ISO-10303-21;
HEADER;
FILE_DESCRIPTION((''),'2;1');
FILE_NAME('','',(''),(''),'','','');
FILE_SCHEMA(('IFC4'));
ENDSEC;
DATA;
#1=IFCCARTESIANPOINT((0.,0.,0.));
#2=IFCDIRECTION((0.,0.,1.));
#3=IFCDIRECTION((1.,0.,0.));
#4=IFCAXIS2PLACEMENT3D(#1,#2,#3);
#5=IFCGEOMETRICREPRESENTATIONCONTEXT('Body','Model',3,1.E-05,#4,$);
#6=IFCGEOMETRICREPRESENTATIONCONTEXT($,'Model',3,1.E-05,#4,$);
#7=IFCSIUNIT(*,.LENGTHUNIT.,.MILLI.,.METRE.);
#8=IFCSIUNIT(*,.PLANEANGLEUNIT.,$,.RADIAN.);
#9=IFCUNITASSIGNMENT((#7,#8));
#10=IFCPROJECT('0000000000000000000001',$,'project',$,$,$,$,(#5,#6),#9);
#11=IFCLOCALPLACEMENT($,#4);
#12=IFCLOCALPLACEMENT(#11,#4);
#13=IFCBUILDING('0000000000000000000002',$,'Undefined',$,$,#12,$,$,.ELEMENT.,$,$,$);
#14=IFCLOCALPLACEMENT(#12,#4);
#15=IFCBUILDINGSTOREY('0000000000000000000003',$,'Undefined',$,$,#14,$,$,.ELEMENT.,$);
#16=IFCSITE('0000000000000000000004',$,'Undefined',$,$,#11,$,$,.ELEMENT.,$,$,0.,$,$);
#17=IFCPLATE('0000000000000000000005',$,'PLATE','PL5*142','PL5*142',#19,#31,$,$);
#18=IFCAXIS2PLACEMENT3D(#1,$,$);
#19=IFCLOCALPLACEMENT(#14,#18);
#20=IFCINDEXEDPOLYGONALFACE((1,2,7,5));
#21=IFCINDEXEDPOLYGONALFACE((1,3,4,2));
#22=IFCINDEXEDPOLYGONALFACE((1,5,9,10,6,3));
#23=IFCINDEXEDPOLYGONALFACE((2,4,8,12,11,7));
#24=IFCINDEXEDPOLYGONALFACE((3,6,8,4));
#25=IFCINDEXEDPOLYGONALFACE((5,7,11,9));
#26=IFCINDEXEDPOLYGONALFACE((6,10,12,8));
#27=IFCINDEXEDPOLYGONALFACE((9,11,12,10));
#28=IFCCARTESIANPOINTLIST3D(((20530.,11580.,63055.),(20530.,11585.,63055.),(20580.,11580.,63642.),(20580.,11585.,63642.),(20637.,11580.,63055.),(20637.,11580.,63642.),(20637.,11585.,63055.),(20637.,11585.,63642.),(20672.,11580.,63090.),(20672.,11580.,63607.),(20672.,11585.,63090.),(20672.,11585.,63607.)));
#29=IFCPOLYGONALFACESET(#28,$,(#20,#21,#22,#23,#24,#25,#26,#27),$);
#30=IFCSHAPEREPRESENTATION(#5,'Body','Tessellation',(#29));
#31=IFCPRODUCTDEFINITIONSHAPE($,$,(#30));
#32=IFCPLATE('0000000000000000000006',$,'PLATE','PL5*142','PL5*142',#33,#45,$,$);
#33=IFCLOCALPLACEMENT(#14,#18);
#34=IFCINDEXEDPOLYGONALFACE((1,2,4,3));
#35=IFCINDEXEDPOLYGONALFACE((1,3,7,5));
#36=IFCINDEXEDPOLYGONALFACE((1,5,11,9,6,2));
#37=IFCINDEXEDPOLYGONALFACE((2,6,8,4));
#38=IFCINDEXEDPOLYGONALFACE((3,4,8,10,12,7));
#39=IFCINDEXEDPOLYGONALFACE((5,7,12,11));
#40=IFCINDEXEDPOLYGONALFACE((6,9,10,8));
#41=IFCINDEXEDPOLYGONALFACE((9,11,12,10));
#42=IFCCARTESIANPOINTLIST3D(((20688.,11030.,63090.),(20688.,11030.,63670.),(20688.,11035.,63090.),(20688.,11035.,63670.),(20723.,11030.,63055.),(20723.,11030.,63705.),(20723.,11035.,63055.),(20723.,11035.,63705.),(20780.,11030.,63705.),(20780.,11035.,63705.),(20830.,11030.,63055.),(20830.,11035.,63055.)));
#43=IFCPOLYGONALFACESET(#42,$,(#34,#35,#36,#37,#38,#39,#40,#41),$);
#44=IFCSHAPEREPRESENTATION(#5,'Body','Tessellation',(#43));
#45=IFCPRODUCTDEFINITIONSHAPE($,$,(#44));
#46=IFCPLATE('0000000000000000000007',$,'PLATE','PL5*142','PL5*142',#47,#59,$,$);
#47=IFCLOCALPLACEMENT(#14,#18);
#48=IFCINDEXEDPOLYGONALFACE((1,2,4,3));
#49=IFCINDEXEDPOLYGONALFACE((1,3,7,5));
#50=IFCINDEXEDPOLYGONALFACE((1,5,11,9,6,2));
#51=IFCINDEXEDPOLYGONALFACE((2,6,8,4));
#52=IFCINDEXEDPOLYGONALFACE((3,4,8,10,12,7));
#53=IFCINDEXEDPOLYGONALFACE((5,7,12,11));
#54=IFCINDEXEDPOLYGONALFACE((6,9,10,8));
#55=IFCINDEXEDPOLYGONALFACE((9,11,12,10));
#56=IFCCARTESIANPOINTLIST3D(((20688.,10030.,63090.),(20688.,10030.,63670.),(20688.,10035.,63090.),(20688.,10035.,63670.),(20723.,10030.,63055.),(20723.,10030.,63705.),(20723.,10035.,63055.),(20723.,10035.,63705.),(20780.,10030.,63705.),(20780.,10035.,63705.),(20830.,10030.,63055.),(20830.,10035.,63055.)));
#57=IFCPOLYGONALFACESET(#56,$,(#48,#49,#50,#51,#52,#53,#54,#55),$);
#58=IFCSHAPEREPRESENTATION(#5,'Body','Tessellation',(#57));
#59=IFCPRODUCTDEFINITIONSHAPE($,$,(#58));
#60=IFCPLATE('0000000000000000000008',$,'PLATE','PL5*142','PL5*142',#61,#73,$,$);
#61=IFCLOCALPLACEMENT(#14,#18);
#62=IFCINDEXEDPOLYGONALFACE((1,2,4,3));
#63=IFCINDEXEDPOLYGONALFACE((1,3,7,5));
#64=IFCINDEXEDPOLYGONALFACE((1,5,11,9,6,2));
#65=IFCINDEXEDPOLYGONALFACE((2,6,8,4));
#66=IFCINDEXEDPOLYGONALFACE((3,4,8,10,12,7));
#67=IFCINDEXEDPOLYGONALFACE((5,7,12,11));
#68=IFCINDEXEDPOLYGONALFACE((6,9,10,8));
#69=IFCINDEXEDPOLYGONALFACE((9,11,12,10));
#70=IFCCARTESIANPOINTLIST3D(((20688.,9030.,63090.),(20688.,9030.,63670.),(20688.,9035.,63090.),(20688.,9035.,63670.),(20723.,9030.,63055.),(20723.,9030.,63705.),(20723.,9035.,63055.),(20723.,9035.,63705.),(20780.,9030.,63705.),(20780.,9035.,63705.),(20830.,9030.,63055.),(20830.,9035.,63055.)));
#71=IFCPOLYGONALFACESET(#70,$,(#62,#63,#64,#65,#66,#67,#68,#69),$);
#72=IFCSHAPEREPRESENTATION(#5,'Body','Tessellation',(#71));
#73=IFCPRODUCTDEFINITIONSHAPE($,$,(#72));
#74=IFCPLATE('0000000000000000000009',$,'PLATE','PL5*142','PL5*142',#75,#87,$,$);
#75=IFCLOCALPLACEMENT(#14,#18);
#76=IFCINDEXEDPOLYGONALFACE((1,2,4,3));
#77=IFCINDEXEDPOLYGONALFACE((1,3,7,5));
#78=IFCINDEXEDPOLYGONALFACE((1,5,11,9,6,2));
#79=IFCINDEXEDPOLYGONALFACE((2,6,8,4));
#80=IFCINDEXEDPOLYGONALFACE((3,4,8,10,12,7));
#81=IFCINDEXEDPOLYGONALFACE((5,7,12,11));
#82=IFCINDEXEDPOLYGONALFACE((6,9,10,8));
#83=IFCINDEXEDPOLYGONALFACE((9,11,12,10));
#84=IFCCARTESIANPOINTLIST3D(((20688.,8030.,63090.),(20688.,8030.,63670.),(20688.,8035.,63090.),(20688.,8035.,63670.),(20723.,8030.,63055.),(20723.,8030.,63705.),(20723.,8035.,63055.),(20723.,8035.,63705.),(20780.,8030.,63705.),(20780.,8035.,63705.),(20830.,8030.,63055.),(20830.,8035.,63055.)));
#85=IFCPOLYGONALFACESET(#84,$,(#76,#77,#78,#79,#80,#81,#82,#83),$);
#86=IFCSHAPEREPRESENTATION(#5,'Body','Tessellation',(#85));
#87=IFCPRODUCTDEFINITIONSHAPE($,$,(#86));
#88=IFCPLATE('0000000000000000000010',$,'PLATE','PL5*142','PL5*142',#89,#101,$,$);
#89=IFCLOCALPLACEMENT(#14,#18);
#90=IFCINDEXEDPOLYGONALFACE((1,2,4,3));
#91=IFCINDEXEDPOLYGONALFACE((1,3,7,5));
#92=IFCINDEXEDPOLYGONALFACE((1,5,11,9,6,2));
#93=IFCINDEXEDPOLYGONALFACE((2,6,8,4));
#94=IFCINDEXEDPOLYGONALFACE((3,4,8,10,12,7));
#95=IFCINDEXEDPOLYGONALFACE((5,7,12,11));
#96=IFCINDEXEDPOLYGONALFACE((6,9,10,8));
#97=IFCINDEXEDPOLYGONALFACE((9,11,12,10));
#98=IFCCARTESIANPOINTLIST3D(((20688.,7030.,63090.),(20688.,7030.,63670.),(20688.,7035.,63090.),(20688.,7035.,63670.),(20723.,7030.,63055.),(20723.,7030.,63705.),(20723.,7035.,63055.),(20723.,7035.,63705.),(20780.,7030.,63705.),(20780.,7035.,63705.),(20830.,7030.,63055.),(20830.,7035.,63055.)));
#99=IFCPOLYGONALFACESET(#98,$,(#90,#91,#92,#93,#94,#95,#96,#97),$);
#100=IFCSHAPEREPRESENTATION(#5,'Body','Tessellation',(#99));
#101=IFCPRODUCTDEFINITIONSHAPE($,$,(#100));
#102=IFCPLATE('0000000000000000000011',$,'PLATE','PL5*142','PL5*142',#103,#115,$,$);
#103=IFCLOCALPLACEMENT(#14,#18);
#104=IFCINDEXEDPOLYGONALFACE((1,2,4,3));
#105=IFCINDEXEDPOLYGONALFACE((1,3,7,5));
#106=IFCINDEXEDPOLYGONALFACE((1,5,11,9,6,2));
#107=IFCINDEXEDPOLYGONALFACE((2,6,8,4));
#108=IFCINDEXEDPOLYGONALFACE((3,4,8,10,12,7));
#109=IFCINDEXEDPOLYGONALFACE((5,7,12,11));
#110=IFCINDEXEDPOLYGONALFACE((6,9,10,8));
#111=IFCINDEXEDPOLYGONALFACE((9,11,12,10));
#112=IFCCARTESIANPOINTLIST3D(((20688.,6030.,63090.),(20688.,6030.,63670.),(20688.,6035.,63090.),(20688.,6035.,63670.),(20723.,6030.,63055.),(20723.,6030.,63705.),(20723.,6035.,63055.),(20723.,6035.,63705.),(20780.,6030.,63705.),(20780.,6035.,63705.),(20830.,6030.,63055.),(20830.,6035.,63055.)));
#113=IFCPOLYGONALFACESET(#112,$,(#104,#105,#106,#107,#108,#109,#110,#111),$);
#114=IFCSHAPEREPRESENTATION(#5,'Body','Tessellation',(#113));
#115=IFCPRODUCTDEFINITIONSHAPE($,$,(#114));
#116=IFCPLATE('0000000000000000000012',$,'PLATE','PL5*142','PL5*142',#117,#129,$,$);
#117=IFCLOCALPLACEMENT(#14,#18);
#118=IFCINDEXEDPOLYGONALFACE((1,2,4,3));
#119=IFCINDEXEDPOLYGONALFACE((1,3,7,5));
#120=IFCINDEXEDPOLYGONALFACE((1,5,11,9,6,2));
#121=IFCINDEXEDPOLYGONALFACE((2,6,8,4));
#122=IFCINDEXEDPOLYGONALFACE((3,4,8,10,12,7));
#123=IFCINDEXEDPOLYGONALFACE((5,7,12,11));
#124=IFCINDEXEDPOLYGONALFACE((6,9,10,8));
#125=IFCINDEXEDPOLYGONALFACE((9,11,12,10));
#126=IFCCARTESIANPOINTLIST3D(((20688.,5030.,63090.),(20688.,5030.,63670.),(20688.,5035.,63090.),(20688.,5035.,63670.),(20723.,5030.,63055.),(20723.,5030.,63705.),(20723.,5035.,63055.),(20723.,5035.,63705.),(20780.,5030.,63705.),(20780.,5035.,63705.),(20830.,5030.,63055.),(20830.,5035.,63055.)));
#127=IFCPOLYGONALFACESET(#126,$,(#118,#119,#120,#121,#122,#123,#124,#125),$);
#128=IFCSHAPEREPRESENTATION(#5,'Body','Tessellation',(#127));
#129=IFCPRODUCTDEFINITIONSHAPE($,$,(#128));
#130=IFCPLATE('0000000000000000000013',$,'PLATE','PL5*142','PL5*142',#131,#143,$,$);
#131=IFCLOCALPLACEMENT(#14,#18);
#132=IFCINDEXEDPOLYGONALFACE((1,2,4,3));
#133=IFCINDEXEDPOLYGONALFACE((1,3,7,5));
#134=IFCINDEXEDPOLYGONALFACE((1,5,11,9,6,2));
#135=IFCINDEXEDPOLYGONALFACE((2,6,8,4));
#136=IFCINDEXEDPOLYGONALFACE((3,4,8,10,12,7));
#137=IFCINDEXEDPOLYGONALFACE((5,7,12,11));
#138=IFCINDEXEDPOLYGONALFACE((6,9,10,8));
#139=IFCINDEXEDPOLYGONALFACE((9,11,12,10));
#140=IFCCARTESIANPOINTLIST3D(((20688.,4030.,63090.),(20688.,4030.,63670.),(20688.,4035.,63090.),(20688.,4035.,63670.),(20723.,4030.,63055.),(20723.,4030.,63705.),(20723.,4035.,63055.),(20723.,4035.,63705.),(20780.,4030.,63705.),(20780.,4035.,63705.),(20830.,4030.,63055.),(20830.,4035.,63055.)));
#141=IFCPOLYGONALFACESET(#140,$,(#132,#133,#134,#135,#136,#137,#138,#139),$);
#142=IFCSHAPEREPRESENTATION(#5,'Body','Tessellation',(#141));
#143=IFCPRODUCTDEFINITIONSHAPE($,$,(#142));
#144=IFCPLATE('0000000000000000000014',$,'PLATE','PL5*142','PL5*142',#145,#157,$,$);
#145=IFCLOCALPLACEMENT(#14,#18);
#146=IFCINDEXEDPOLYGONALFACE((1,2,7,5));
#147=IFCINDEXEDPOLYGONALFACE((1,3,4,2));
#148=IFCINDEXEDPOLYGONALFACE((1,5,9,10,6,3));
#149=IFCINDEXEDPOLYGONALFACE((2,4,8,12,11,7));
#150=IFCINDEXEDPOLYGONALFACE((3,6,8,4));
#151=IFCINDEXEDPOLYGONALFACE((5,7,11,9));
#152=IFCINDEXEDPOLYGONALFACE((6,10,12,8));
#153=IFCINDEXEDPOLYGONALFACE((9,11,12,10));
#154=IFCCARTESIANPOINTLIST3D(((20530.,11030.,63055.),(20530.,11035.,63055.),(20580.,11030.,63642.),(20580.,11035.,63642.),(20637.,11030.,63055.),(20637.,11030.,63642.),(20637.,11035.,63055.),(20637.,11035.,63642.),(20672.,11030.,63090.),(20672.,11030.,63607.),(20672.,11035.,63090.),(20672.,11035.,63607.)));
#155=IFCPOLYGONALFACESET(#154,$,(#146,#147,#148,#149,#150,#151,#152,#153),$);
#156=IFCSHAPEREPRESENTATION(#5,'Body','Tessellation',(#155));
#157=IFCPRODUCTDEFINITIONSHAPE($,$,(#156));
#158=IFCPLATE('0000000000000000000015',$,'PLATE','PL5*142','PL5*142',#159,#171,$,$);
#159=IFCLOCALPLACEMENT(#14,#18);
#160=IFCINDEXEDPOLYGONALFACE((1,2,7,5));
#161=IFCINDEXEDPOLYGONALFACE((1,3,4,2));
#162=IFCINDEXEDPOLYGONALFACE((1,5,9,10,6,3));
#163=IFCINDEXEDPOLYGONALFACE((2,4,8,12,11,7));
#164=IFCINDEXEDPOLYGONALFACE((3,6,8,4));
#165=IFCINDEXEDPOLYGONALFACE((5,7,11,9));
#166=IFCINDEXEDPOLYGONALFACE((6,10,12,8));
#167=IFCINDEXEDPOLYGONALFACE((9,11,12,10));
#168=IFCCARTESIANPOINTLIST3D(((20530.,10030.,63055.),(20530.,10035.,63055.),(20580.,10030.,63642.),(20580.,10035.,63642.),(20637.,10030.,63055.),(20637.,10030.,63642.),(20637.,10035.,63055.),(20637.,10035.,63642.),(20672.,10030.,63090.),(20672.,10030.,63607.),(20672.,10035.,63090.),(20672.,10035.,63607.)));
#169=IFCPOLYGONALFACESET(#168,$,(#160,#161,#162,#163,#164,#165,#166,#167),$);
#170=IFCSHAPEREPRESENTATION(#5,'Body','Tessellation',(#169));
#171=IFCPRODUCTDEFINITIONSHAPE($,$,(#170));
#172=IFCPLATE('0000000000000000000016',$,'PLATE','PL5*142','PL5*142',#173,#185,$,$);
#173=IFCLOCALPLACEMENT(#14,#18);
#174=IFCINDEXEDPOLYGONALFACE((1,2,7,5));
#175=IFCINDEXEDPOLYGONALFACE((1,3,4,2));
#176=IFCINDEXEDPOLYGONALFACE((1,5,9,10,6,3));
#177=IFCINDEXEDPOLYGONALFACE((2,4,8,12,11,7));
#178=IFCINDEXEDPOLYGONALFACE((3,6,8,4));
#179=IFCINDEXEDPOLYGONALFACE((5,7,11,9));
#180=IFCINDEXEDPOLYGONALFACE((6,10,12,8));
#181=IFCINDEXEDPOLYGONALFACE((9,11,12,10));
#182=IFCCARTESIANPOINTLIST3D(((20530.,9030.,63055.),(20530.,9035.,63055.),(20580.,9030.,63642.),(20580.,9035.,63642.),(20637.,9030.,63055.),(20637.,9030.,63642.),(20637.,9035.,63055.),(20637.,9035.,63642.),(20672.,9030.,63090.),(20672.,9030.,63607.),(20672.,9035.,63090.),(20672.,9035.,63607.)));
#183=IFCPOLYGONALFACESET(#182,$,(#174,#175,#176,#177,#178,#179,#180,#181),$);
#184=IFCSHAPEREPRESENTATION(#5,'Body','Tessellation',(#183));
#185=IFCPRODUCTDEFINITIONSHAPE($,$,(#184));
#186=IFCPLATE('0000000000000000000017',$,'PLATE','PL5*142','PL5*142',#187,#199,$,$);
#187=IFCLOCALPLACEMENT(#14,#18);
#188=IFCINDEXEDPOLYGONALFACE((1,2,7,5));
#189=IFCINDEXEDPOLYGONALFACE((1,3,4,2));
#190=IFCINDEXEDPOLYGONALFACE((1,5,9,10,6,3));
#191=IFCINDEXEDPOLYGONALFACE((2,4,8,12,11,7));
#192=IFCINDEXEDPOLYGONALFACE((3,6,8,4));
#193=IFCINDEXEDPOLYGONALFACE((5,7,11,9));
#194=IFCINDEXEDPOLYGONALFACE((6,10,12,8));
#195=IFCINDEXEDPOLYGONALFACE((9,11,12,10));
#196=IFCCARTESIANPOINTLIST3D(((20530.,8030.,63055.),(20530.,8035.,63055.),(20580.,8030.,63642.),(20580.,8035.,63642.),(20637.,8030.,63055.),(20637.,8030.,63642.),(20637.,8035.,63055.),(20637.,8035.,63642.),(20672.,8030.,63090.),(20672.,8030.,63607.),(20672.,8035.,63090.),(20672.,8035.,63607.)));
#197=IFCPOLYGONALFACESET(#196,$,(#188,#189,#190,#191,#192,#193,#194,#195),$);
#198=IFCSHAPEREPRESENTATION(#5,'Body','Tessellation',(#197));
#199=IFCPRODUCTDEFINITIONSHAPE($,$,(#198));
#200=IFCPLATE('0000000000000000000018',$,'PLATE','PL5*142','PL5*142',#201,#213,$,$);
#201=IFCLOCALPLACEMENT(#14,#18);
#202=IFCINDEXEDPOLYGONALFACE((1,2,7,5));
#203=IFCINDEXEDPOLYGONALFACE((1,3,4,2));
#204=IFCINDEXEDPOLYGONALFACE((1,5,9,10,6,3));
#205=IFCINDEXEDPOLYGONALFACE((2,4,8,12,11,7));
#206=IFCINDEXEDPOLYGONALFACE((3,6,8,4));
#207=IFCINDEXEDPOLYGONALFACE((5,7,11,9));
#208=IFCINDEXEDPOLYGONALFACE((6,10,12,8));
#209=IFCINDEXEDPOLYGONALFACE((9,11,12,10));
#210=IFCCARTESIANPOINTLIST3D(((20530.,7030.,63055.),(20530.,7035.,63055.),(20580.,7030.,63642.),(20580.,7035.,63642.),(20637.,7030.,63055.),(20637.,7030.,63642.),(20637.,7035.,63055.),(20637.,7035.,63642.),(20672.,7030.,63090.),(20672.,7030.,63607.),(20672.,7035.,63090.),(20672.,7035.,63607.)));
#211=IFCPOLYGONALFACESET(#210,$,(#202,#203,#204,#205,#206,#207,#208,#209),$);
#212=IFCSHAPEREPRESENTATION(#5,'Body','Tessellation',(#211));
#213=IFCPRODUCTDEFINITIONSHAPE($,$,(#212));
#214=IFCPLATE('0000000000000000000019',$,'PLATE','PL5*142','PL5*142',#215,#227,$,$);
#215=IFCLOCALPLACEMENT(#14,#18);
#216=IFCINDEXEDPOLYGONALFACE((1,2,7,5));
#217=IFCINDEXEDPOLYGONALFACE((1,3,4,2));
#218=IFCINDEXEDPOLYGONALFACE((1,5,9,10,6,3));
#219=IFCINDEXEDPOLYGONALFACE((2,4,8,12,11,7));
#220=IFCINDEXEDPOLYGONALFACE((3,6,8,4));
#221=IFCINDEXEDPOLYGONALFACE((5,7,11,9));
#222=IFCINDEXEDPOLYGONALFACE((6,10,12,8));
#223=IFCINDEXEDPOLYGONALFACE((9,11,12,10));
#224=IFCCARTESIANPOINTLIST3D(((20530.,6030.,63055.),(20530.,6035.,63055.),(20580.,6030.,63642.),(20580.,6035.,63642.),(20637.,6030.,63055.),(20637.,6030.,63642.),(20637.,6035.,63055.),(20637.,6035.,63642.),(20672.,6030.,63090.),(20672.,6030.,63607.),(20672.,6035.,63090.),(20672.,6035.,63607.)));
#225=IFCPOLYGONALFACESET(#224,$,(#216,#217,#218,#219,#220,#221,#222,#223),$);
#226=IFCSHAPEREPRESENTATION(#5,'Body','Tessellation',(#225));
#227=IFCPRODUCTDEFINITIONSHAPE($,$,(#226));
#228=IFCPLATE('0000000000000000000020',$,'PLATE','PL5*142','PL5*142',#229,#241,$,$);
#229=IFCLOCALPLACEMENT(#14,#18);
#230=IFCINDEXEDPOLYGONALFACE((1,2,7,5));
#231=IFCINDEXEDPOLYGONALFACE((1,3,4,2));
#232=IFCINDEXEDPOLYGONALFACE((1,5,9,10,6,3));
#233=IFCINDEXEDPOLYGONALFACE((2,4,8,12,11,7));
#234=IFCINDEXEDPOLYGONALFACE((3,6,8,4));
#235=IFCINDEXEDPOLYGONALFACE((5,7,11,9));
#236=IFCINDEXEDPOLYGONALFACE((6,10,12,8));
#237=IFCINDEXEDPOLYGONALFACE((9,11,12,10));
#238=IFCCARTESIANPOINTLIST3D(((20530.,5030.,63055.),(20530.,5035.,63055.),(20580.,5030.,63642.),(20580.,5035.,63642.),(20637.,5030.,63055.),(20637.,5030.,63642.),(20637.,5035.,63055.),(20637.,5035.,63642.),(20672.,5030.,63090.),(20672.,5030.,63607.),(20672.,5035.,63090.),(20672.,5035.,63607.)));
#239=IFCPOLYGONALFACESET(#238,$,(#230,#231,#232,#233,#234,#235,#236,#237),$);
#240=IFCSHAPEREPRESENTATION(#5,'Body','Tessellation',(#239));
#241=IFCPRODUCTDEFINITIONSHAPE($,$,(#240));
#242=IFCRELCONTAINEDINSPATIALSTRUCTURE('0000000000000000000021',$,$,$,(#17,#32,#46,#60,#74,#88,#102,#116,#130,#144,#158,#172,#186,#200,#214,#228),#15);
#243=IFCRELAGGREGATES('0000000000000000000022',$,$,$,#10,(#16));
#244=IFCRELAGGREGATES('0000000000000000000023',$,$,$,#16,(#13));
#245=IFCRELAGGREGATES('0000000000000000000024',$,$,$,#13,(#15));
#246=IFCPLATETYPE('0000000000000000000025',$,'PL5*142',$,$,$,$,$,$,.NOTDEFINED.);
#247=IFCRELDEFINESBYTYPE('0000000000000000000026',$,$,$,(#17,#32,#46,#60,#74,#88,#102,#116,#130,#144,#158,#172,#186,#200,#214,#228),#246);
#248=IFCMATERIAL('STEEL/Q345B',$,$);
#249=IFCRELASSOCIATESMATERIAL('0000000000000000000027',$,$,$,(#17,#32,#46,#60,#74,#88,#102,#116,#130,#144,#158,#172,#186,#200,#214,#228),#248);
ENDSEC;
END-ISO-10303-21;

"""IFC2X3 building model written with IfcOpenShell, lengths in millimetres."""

from ifc_helpers import new_model, si_unit, frame, origin_with_axes, place, context, project, spatial, polyline, outline, extrude, material, type_object, element, save


model = new_model("IFC2X3")

# Units and contexts
model_context_1 = context("Model", 3, precision=1e-05, world=origin_with_axes(), identifier="Body")
model_context_2 = context("Model", 3, precision=1e-05, world=origin_with_axes())
ifc_project = project(units=[si_unit("LENGTHUNIT", "METRE", prefix="MILLI"), si_unit("PLANEANGLEUNIT", "RADIAN")], contexts=[model_context_1, model_context_2])

# Site, building, storey
site_placement = place(None, origin_with_axes())
site = spatial("IfcSite", under=ifc_project, at=site_placement, Name="Undefined", CompositionType="ELEMENT", RefElevation=0.0)
building_placement = place(site_placement, origin_with_axes())
building = spatial("IfcBuilding", under=site, at=building_placement, Name="Undefined", CompositionType="ELEMENT")
storey_placement = place(building_placement, origin_with_axes())
storey = spatial("IfcBuildingStorey", under=building, at=storey_placement, Name="Undefined", CompositionType="ELEMENT")

# Shared definitions
ifc_material_1 = material(Name="STEEL/Q345B")

# Plates
plate_type_1 = type_object("IfcPlateType", Name="PL5*142", PredefinedType="NOTDEFINED")
plate_1_placement = place(storey_placement, frame((20672.0, 11582.5, 63642.0), z_axis=(0.0, -1.0, 0.0), x_axis=(-1.0, 0.0, 0.0)))
element("IfcPlate", 1, at=plate_1_placement, inside=storey, type_object=plate_type_1, material=ifc_material_1, Name="PLATE", Description="PL5*142", ObjectType="PL5*142", context=model_context_1, shape_type="SweptSolid", body=[
    extrude(outline(polyline([(0.0, 35.0), (35.0, 0.0), (92.0, 0.0), (142.0, 587.0), (35.0, 587.0), (0.0, 552.0), (0.0, 35.0)])), frame((0.0, 0.0, -2.5), z_axis=(0.0, 0.0, 1.0), x_axis=(1.0, 0.0, 0.0)), (0.0, 0.0, 1.0), 5.0),
])
for number, where, z_axis, x_axis, name in (
    (2, (20830.0, 11032.5, 63055.0), (0.0, 1.0, 0.0), (-1.0, 0.0, 0.0), "PLATE"),
    (3, (20830.0, 10032.5, 63055.0), (0.0, 1.0, 0.0), (-1.0, 0.0, 0.0), "PLATE"),
    (4, (20830.0, 9032.5, 63055.0), (0.0, 1.0, 0.0), (-1.0, 0.0, 0.0), "PLATE"),
    (5, (20830.0, 8032.5, 63055.0), (0.0, 1.0, 0.0), (-1.0, 0.0, 0.0), "PLATE"),
    (6, (20830.0, 7032.5, 63055.0), (0.0, 1.0, 0.0), (-1.0, 0.0, 0.0), "PLATE"),
    (7, (20830.0, 6032.5, 63055.0), (0.0, 1.0, 0.0), (-1.0, 0.0, 0.0), "PLATE"),
    (8, (20830.0, 5032.5, 63055.0), (0.0, 1.0, 0.0), (-1.0, 0.0, 0.0), "PLATE"),
    (9, (20830.0, 4032.5, 63055.0), (0.0, 1.0, 0.0), (-1.0, 0.0, 0.0), "PLATE"),
):
    element("IfcPlate", number, at=place(storey_placement, frame(where, z_axis=z_axis, x_axis=x_axis)), inside=storey, type_object=plate_type_1, material=ifc_material_1, Name=name, Description="PL5*142", ObjectType="PL5*142", context=model_context_1, shape_type="SweptSolid", body=[
        extrude(outline(polyline([(0.0, 0.0), (107.0, 0.0), (142.0, 35.0), (142.0, 615.0), (107.0, 650.0), (50.0, 650.0), (0.0, 0.0)])), frame((0.0, 0.0, -2.5), z_axis=(0.0, 0.0, 1.0), x_axis=(1.0, 0.0, 0.0)), (0.0, 0.0, 1.0), 5.0),
    ])
for number, where, z_axis, x_axis, name in (
    (10, (20672.0, 11032.5, 63642.0), (0.0, -1.0, 0.0), (-1.0, 0.0, 0.0), "PLATE"),
    (11, (20672.0, 10032.5, 63642.0), (0.0, -1.0, 0.0), (-1.0, 0.0, 0.0), "PLATE"),
    (12, (20672.0, 9032.5, 63642.0), (0.0, -1.0, 0.0), (-1.0, 0.0, 0.0), "PLATE"),
    (13, (20672.0, 8032.5, 63642.0), (0.0, -1.0, 0.0), (-1.0, 0.0, 0.0), "PLATE"),
    (14, (20672.0, 7032.5, 63642.0), (0.0, -1.0, 0.0), (-1.0, 0.0, 0.0), "PLATE"),
    (15, (20672.0, 6032.5, 63642.0), (0.0, -1.0, 0.0), (-1.0, 0.0, 0.0), "PLATE"),
    (16, (20672.0, 5032.5, 63642.0), (0.0, -1.0, 0.0), (-1.0, 0.0, 0.0), "PLATE"),
):
    element("IfcPlate", number, at=place(storey_placement, frame(where, z_axis=z_axis, x_axis=x_axis)), inside=storey, type_object=plate_type_1, material=ifc_material_1, Name=name, Description="PL5*142", ObjectType="PL5*142", context=model_context_1, shape_type="SweptSolid", body=[
        extrude(outline(polyline([(0.0, 35.0), (35.0, 0.0), (92.0, 0.0), (142.0, 587.0), (35.0, 587.0), (0.0, 552.0), (0.0, 35.0)])), frame((0.0, 0.0, -2.5), z_axis=(0.0, 0.0, 1.0), x_axis=(1.0, 0.0, 0.0)), (0.0, 0.0, 1.0), 5.0),
    ])

save(model, "model.ifc")
